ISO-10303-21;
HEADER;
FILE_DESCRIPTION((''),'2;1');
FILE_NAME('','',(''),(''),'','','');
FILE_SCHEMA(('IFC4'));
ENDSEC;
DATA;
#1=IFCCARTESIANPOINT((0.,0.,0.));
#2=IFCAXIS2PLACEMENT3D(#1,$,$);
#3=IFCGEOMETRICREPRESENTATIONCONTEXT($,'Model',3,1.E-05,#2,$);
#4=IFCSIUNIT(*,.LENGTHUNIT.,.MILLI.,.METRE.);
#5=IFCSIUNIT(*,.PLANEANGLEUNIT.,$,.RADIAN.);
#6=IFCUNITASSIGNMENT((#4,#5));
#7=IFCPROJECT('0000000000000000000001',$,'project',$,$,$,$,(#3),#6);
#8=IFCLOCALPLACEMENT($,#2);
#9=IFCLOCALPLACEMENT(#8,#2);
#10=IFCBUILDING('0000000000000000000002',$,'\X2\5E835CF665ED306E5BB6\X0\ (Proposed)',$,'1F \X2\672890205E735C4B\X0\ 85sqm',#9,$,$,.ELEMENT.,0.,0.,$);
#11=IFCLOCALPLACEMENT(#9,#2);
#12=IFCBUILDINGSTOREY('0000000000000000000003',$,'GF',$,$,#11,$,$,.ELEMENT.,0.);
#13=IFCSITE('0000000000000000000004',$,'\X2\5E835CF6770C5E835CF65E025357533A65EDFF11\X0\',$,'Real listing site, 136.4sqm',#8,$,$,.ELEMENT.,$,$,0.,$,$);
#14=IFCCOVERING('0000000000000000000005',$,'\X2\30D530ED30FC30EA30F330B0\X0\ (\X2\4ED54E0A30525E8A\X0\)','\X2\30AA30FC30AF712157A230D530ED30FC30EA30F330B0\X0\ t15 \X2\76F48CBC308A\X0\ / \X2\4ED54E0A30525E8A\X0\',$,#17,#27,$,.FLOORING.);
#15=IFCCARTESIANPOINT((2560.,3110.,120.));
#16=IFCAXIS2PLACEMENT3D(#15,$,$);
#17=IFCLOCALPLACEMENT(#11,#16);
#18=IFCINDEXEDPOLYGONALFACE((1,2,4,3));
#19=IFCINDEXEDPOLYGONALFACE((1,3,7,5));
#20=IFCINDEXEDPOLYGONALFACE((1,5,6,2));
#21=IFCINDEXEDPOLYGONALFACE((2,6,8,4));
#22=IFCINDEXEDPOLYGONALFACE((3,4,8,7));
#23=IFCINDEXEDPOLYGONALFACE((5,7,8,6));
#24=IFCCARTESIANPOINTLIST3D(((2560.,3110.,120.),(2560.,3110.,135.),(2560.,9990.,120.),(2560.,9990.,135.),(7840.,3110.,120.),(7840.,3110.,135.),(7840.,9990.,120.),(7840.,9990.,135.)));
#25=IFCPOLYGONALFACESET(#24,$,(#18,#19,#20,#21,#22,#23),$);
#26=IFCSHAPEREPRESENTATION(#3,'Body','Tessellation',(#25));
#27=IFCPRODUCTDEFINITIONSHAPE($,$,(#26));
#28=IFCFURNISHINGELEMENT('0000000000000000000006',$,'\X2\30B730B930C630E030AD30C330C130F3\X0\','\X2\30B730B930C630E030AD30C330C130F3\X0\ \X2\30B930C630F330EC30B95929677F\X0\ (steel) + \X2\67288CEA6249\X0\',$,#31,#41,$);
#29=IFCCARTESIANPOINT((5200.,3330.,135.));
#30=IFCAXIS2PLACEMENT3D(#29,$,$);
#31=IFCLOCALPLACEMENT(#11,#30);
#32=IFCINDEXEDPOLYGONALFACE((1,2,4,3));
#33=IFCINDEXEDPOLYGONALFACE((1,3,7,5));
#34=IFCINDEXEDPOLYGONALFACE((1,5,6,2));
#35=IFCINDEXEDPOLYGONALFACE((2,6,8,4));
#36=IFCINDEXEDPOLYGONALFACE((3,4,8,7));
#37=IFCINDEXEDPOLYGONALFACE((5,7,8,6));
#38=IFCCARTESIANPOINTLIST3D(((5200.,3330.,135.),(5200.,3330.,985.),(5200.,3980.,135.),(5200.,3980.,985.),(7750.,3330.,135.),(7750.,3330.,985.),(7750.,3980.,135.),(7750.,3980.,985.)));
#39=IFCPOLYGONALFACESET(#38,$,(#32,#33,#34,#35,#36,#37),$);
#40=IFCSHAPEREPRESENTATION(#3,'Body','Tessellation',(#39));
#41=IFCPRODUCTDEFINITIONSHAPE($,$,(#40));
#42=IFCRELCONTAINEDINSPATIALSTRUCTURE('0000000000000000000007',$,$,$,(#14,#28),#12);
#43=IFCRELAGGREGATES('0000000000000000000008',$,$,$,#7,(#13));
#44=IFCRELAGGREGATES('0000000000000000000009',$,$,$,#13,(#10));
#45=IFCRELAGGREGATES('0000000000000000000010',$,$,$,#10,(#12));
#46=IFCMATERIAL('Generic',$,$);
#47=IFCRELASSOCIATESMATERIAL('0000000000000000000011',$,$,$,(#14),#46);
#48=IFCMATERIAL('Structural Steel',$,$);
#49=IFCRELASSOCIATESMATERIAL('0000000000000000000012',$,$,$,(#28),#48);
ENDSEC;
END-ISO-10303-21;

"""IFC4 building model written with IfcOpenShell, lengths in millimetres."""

from ifc_helpers import new_model, si_unit, frame, frame_2d, origin, place, context, project, spatial, rectangle, extrude, material, element, save


model = new_model("IFC4")

# Units and contexts
model_context = context("Model", 3, precision=1e-05, world=origin())
ifc_project = project(units=[si_unit("LENGTHUNIT", "METRE", prefix="MILLI"), si_unit("PLANEANGLEUNIT", "RADIAN")], contexts=[model_context])

# Site, building, storey
site_placement = place(None, origin())
site = spatial("IfcSite", under=ifc_project, at=site_placement, Name="広島県広島市南区旭１", ObjectType="Real listing site, 136.4sqm", CompositionType="ELEMENT", RefElevation=0.0)
building_placement = place(site_placement, origin())
building = spatial("IfcBuilding", under=site, at=building_placement, Name="広島旭の家 (Proposed)", ObjectType="1F 木造平屋 85sqm", CompositionType="ELEMENT", ElevationOfRefHeight=0.0, ElevationOfTerrain=0.0)
storey_placement = place(building_placement, origin())
storey = spatial("IfcBuildingStorey", under=building, at=storey_placement, Name="GF", CompositionType="ELEMENT", Elevation=0.0)

# Shared definitions
ifc_material_1 = material(Name="Generic")

# Covering
covering_placement = place(storey_placement, frame((2560.0, 3110.0, 120.0)))
element("IfcCovering", 1, at=covering_placement, inside=storey, material=ifc_material_1, Name="フローリング (仕上げ床)", Description="オーク無垢フローリング t15 直貼り / 仕上げ床", PredefinedType="FLOORING", context=model_context, shape_type="SweptSolid", body=[
    extrude(rectangle(XDim=5280.0, YDim=6880.0, at=frame_2d((2640.0, 3440.0))), frame((2560.0, 3110.0, 120.0)), (0.0, 0.0, 1.0), 15.0),
])

# Furnishing element
ifc_material_2 = material(Name="Structural Steel")
furnishing_placement = place(storey_placement, frame((5200.0, 3330.0, 135.0)))
element("IfcFurnishingElement", 2, at=furnishing_placement, inside=storey, material=ifc_material_2, Name="システムキッチン", Description="システムキッチン ステンレス天板 (steel) + 木質扉", context=model_context, shape_type="SweptSolid", body=[
    extrude(rectangle(XDim=2550.0, YDim=650.0, at=frame_2d((1275.0, 325.0))), frame((5200.0, 3330.0, 135.0)), (0.0, 0.0, 1.0), 850.0),
])

save(model, "model.ifc")
